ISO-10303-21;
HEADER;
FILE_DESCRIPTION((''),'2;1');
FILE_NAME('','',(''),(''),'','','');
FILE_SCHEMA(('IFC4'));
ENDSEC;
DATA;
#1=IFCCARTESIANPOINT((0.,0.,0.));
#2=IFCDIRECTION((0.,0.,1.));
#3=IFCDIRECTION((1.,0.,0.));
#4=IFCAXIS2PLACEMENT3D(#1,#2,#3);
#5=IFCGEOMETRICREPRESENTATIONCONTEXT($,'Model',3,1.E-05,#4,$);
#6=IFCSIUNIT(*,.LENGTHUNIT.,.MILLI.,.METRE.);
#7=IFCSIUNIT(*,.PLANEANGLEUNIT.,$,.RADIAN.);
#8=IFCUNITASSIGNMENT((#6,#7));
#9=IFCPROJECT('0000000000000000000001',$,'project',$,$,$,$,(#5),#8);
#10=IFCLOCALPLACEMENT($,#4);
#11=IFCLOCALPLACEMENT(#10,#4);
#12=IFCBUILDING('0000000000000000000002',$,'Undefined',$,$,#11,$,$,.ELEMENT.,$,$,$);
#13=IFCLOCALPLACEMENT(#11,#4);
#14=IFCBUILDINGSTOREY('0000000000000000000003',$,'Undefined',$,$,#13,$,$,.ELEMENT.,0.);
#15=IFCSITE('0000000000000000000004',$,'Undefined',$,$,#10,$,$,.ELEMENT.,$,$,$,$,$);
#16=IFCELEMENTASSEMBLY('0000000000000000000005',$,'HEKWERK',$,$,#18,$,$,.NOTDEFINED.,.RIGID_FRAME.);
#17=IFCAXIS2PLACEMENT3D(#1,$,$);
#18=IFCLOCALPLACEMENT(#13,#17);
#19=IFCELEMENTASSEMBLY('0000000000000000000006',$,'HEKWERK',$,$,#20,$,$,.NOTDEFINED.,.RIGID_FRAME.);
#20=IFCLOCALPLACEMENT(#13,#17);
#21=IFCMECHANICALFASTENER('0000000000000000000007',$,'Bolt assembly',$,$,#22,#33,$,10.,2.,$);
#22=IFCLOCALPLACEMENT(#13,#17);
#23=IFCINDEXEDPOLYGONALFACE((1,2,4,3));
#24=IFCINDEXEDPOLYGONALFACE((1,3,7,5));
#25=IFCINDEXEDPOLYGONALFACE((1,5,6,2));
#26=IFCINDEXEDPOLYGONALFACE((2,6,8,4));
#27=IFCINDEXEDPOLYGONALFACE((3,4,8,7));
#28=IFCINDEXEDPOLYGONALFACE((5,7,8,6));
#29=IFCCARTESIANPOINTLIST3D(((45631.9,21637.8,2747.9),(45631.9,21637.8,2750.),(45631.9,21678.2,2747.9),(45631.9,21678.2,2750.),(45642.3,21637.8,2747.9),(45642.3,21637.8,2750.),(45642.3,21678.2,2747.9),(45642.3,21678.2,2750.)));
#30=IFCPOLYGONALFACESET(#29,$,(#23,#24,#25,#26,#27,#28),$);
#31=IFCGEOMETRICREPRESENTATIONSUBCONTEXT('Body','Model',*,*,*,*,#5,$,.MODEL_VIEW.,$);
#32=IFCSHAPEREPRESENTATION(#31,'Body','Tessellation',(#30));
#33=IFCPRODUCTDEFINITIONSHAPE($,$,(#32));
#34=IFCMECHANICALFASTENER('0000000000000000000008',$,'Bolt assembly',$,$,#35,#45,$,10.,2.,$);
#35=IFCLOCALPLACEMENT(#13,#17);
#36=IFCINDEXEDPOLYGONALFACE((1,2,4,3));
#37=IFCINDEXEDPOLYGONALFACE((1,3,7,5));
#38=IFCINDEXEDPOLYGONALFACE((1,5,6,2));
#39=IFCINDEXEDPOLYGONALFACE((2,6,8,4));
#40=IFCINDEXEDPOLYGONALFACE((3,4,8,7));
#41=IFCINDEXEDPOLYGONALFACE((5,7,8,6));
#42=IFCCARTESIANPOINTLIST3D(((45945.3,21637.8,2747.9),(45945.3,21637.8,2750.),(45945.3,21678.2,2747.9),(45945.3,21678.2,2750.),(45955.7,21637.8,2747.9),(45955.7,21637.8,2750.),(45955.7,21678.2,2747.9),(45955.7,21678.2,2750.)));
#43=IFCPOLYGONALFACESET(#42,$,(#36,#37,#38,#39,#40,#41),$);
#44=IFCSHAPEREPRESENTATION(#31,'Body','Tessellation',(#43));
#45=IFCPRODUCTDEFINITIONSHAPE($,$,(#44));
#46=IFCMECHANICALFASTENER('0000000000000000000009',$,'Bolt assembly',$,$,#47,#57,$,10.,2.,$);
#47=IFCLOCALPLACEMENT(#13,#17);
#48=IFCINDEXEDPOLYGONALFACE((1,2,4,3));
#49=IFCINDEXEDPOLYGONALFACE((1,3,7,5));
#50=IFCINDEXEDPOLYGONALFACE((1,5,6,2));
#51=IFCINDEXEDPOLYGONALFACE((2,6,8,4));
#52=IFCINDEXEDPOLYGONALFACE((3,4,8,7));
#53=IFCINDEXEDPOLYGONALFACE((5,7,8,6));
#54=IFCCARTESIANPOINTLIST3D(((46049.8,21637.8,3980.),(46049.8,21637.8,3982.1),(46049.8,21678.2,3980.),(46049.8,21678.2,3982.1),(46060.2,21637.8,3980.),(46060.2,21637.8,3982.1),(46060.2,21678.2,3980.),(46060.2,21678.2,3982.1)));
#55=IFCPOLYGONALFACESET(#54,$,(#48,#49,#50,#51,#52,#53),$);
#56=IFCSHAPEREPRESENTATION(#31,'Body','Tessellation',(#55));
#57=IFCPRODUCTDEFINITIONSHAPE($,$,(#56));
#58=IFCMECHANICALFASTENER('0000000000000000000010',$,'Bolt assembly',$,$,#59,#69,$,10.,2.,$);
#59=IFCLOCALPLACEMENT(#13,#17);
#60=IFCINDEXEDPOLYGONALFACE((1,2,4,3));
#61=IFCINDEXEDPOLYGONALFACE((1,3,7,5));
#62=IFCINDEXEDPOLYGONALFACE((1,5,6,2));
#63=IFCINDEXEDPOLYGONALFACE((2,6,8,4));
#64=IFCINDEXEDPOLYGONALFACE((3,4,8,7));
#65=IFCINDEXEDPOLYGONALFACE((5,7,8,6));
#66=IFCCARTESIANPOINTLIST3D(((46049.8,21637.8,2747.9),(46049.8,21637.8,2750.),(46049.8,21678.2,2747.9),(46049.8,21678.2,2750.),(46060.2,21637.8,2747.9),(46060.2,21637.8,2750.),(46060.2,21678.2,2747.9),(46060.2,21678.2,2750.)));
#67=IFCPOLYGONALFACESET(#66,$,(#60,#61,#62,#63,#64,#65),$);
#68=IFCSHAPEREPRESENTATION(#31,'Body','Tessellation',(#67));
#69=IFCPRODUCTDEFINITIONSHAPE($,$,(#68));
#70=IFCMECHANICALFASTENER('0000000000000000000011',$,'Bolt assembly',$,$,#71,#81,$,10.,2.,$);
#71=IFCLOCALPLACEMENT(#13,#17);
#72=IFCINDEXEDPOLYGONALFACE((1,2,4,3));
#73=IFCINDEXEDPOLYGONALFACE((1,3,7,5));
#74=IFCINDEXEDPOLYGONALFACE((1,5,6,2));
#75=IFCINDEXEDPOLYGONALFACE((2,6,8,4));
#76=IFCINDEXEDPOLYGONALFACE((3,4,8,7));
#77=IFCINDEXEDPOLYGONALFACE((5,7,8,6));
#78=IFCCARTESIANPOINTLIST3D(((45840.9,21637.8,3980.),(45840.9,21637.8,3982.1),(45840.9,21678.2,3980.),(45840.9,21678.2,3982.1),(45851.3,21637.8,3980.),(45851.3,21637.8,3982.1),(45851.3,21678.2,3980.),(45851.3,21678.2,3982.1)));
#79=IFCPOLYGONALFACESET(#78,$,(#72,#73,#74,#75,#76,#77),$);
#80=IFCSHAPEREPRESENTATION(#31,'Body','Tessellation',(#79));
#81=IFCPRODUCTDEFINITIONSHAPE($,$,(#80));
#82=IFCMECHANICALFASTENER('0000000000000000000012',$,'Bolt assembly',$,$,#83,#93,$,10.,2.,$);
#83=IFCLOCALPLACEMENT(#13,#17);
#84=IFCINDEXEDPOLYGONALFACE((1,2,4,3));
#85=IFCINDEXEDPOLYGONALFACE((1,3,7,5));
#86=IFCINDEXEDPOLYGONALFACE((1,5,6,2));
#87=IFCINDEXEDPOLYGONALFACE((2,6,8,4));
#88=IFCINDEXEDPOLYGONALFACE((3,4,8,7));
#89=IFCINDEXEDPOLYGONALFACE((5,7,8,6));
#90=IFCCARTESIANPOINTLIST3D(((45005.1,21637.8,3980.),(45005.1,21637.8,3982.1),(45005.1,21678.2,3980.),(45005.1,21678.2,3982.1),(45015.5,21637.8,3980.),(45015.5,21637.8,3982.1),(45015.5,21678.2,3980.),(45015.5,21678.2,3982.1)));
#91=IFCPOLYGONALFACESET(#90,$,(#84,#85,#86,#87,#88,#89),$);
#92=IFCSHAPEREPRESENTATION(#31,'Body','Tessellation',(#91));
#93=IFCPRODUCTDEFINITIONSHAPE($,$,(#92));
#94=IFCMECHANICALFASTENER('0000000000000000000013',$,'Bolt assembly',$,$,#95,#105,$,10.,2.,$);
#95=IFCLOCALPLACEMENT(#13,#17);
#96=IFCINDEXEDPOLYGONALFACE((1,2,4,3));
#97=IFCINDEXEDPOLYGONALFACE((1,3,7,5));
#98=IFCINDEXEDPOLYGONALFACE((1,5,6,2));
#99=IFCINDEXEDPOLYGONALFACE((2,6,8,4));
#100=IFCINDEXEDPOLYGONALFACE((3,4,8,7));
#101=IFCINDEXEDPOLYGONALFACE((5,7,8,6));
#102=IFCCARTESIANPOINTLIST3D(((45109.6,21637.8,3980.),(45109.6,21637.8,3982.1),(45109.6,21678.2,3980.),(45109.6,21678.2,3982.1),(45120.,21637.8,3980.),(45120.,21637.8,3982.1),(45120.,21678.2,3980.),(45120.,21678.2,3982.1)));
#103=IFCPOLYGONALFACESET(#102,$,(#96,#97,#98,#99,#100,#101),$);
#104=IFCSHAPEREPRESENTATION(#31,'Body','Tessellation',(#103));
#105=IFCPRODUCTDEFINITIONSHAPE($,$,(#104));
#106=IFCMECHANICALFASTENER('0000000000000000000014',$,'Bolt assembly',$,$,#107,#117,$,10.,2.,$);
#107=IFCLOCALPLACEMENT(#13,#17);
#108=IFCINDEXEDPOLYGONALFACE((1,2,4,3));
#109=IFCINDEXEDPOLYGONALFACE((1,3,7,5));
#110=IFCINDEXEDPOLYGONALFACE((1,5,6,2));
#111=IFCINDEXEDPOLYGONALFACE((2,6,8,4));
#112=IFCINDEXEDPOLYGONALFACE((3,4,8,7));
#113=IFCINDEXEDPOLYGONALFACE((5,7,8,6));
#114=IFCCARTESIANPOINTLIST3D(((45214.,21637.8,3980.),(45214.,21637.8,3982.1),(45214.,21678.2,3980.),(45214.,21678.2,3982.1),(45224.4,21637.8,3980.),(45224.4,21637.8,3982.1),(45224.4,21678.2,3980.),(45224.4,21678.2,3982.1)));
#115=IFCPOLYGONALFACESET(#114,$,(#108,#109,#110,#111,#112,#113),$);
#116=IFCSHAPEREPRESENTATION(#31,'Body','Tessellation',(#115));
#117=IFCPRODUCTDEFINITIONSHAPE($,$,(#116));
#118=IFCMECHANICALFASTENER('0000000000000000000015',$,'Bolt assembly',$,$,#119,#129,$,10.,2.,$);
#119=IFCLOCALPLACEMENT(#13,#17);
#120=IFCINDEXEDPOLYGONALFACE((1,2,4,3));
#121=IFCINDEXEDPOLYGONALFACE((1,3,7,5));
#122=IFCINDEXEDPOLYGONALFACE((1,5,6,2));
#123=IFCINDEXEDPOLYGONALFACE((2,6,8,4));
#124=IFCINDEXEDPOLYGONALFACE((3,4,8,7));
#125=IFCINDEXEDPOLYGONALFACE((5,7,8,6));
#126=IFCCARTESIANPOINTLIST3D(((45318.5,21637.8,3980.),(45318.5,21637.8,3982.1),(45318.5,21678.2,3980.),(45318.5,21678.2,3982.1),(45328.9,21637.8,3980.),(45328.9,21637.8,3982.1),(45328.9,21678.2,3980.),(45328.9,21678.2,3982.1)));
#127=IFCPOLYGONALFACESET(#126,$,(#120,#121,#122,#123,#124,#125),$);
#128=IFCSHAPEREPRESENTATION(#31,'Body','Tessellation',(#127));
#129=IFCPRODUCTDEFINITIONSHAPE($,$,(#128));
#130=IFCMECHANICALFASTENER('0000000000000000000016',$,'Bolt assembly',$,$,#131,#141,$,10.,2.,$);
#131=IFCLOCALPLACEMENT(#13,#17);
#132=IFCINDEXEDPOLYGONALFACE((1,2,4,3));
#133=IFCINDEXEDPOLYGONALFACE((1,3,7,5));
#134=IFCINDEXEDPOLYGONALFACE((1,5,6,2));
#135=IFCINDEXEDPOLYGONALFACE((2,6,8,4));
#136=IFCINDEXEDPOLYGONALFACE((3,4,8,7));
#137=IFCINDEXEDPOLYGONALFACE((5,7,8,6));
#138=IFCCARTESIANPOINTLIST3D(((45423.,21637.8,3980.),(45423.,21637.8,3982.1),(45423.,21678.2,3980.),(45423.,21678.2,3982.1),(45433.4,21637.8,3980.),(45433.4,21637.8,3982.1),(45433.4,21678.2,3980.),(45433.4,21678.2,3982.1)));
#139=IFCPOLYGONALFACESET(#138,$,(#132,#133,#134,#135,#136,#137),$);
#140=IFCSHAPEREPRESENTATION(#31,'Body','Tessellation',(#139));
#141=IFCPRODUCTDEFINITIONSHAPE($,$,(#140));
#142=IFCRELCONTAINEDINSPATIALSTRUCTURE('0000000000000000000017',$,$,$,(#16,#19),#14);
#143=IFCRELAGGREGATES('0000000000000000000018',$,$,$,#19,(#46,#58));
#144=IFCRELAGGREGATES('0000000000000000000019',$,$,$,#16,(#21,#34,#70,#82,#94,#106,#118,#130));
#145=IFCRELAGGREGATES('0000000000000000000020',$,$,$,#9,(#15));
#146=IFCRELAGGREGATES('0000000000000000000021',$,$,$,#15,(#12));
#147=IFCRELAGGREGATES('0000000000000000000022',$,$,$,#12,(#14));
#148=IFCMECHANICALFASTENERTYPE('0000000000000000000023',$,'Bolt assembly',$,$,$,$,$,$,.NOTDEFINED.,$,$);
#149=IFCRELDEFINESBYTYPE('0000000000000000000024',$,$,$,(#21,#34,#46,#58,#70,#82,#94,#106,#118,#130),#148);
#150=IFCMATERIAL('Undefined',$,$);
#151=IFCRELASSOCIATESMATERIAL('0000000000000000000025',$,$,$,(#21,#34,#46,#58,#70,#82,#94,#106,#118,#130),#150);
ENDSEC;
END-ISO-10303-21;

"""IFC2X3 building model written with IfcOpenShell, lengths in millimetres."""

from ifc_helpers import new_model, si_unit, frame, origin_with_axes, place, context, subcontext, project, spatial, polyline, segment, composite_curve, outline, extrude, source, transform, mapped, material, type_object, element, aggregate, save


model = new_model("IFC2X3")

# Units and contexts
model_context = context("Model", 3, precision=1e-05, world=origin_with_axes())
body_context = subcontext(model_context, "Body", "Model", "MODEL_VIEW")
ifc_project = project(units=[si_unit("LENGTHUNIT", "METRE", prefix="MILLI"), si_unit("PLANEANGLEUNIT", "RADIAN")], contexts=[model_context])

# Site, building, storey
site_placement = place(None, origin_with_axes())
site = spatial("IfcSite", under=ifc_project, at=site_placement, Name="Undefined", CompositionType="ELEMENT")
building_placement = place(site_placement, origin_with_axes())
building = spatial("IfcBuilding", under=site, at=building_placement, Name="Undefined", CompositionType="ELEMENT")
storey_placement = place(building_placement, origin_with_axes())
storey = spatial("IfcBuildingStorey", under=building, at=storey_placement, Name="Undefined", CompositionType="ELEMENT", Elevation=0.0)

# Element assembly
assembly_1_placement = place(storey_placement, origin_with_axes())
assembly_1 = element("IfcElementAssembly", 1, at=assembly_1_placement, inside=storey, Name="HEKWERK", AssemblyPlace="NOTDEFINED", PredefinedType="RIGID_FRAME")

# Element assembly
assembly_2_placement = place(storey_placement, origin_with_axes())
assembly_2 = element("IfcElementAssembly", 2, at=assembly_2_placement, inside=storey, Name="HEKWERK", AssemblyPlace="NOTDEFINED", PredefinedType="RIGID_FRAME")

# Mechanical fasteners
ifc_material_1 = material(Name="Undefined")
mechanical_fastener_type = type_object("IfcMechanicalFastenerType", Name="Bolt assembly")
shared_shape_1 = source(origin_with_axes(), body_context, "Body", "SweptSolid", [
    extrude(outline(composite_curve([segment(polyline([(-20.2, 5.2), (20.2, 5.2)]), True, "CONTINUOUS"), segment(polyline([(20.2, 5.2), (20.2, -5.2)]), True, "CONTINUOUS"), segment(polyline([(20.2, -5.2), (-20.2, -5.2)]), True, "CONTINUOUS"), segment(polyline([(-20.2, -5.2), (-20.2, 5.2)]), True, "CONTINUOUS")], self_intersect=False)), frame((0.0, -1.0, 0.0), z_axis=(0.0, 1.0, 0.0), x_axis=(1.0, 0.0, 0.0)), (0.0, 0.0, 1.0), 2.1),
])
mechanical_fastener_1_placement = place(assembly_1_placement, frame((45637.1, 21658.0, 2749.0), z_axis=(-1.0, 0.0, 0.0), x_axis=(0.0, 1.0, 0.0)))
mechanical_fastener_1 = element("IfcMechanicalFastener", 3, at=mechanical_fastener_1_placement, type_object=mechanical_fastener_type, material=ifc_material_1, Name="Bolt assembly", NominalDiameter=10.0, NominalLength=2.0, context=body_context, shape_type="MappedRepresentation", body=[
    mapped(shared_shape_1, transform((0.0, 0.0, 0.0))),
])
shared_shape_2 = source(origin_with_axes(), body_context, "Body", "SweptSolid", [
    extrude(outline(composite_curve([segment(polyline([(-20.2, 5.2), (20.2, 5.2)]), True, "CONTINUOUS"), segment(polyline([(20.2, 5.2), (20.2, -5.2)]), True, "CONTINUOUS"), segment(polyline([(20.2, -5.2), (-20.2, -5.2)]), True, "CONTINUOUS"), segment(polyline([(-20.2, -5.2), (-20.2, 5.2)]), True, "CONTINUOUS")], self_intersect=False)), frame((0.0, -1.0, 0.0), z_axis=(0.0, 1.0, 0.0), x_axis=(1.0, 0.0, 0.0)), (0.0, 0.0, 1.0), 2.1),
])
mechanical_fastener_2_placement = place(assembly_1_placement, frame((45950.5, 21658.0, 2749.0), z_axis=(-1.0, 0.0, 0.0), x_axis=(0.0, 1.0, 0.0)))
mechanical_fastener_2 = element("IfcMechanicalFastener", 4, at=mechanical_fastener_2_placement, type_object=mechanical_fastener_type, material=ifc_material_1, Name="Bolt assembly", NominalDiameter=10.0, NominalLength=2.0, context=body_context, shape_type="MappedRepresentation", body=[
    mapped(shared_shape_2, transform((0.0, 0.0, 0.0))),
])
shared_shape_3 = source(origin_with_axes(), body_context, "Body", "SweptSolid", [
    extrude(outline(composite_curve([segment(polyline([(-20.2, 5.2), (20.2, 5.2)]), True, "CONTINUOUS"), segment(polyline([(20.2, 5.2), (20.2, -5.2)]), True, "CONTINUOUS"), segment(polyline([(20.2, -5.2), (-20.2, -5.2)]), True, "CONTINUOUS"), segment(polyline([(-20.2, -5.2), (-20.2, 5.2)]), True, "CONTINUOUS")], self_intersect=False)), frame((0.0, -1.0, 0.0), z_axis=(0.0, 1.0, 0.0), x_axis=(1.0, 0.0, 0.0)), (0.0, 0.0, 1.0), 2.1),
])
mechanical_fastener_3_placement = place(assembly_2_placement, frame((46055.0, 21658.0, 3981.0), z_axis=(1.0, 0.0, 0.0), x_axis=(0.0, 1.0, 0.0)))
mechanical_fastener_3 = element("IfcMechanicalFastener", 5, at=mechanical_fastener_3_placement, type_object=mechanical_fastener_type, material=ifc_material_1, Name="Bolt assembly", NominalDiameter=10.0, NominalLength=2.0, context=body_context, shape_type="MappedRepresentation", body=[
    mapped(shared_shape_3, transform((0.0, 0.0, 0.0))),
])
shared_shape_4 = source(origin_with_axes(), body_context, "Body", "SweptSolid", [
    extrude(outline(composite_curve([segment(polyline([(-20.2, 5.2), (20.2, 5.2)]), True, "CONTINUOUS"), segment(polyline([(20.2, 5.2), (20.2, -5.2)]), True, "CONTINUOUS"), segment(polyline([(20.2, -5.2), (-20.2, -5.2)]), True, "CONTINUOUS"), segment(polyline([(-20.2, -5.2), (-20.2, 5.2)]), True, "CONTINUOUS")], self_intersect=False)), frame((0.0, -1.0, 0.0), z_axis=(0.0, 1.0, 0.0), x_axis=(1.0, 0.0, 0.0)), (0.0, 0.0, 1.0), 2.1),
])
mechanical_fastener_4_placement = place(assembly_2_placement, frame((46055.0, 21658.0, 2749.0), z_axis=(-1.0, 0.0, 0.0), x_axis=(0.0, 1.0, 0.0)))
mechanical_fastener_4 = element("IfcMechanicalFastener", 6, at=mechanical_fastener_4_placement, type_object=mechanical_fastener_type, material=ifc_material_1, Name="Bolt assembly", NominalDiameter=10.0, NominalLength=2.0, context=body_context, shape_type="MappedRepresentation", body=[
    mapped(shared_shape_4, transform((0.0, 0.0, 0.0))),
])
aggregate(assembly_2, [mechanical_fastener_3, mechanical_fastener_4])
shared_shape_5 = source(origin_with_axes(), body_context, "Body", "SweptSolid", [
    extrude(outline(composite_curve([segment(polyline([(-20.2, 5.2), (20.2, 5.2)]), True, "CONTINUOUS"), segment(polyline([(20.2, 5.2), (20.2, -5.2)]), True, "CONTINUOUS"), segment(polyline([(20.2, -5.2), (-20.2, -5.2)]), True, "CONTINUOUS"), segment(polyline([(-20.2, -5.2), (-20.2, 5.2)]), True, "CONTINUOUS")], self_intersect=False)), frame((0.0, -1.0, 0.0), z_axis=(0.0, 1.0, 0.0), x_axis=(1.0, 0.0, 0.0)), (0.0, 0.0, 1.0), 2.1),
])
mechanical_fastener_5_placement = place(assembly_1_placement, frame((45846.1, 21658.0, 3981.0), z_axis=(1.0, 0.0, 0.0), x_axis=(0.0, 1.0, 0.0)))
mechanical_fastener_5 = element("IfcMechanicalFastener", 7, at=mechanical_fastener_5_placement, type_object=mechanical_fastener_type, material=ifc_material_1, Name="Bolt assembly", NominalDiameter=10.0, NominalLength=2.0, context=body_context, shape_type="MappedRepresentation", body=[
    mapped(shared_shape_5, transform((0.0, 0.0, 0.0))),
])
shared_shape_6 = source(origin_with_axes(), body_context, "Body", "SweptSolid", [
    extrude(outline(composite_curve([segment(polyline([(-20.2, 5.2), (20.2, 5.2)]), True, "CONTINUOUS"), segment(polyline([(20.2, 5.2), (20.2, -5.2)]), True, "CONTINUOUS"), segment(polyline([(20.2, -5.2), (-20.2, -5.2)]), True, "CONTINUOUS"), segment(polyline([(-20.2, -5.2), (-20.2, 5.2)]), True, "CONTINUOUS")], self_intersect=False)), frame((0.0, -1.0, 0.0), z_axis=(0.0, 1.0, 0.0), x_axis=(1.0, 0.0, 0.0)), (0.0, 0.0, 1.0), 2.1),
])
mechanical_fastener_6_placement = place(assembly_1_placement, frame((45010.3, 21658.0, 3981.0), z_axis=(1.0, 0.0, 0.0), x_axis=(0.0, 1.0, 0.0)))
mechanical_fastener_6 = element("IfcMechanicalFastener", 8, at=mechanical_fastener_6_placement, type_object=mechanical_fastener_type, material=ifc_material_1, Name="Bolt assembly", NominalDiameter=10.0, NominalLength=2.0, context=body_context, shape_type="MappedRepresentation", body=[
    mapped(shared_shape_6, transform((0.0, 0.0, 0.0))),
])
shared_shape_7 = source(origin_with_axes(), body_context, "Body", "SweptSolid", [
    extrude(outline(composite_curve([segment(polyline([(-20.2, 5.2), (20.2, 5.2)]), True, "CONTINUOUS"), segment(polyline([(20.2, 5.2), (20.2, -5.2)]), True, "CONTINUOUS"), segment(polyline([(20.2, -5.2), (-20.2, -5.2)]), True, "CONTINUOUS"), segment(polyline([(-20.2, -5.2), (-20.2, 5.2)]), True, "CONTINUOUS")], self_intersect=False)), frame((0.0, -1.0, 0.0), z_axis=(0.0, 1.0, 0.0), x_axis=(1.0, 0.0, 0.0)), (0.0, 0.0, 1.0), 2.1),
])
mechanical_fastener_7_placement = place(assembly_1_placement, frame((45114.8, 21658.0, 3981.0), z_axis=(1.0, 0.0, 0.0), x_axis=(0.0, 1.0, 0.0)))
mechanical_fastener_7 = element("IfcMechanicalFastener", 9, at=mechanical_fastener_7_placement, type_object=mechanical_fastener_type, material=ifc_material_1, Name="Bolt assembly", NominalDiameter=10.0, NominalLength=2.0, context=body_context, shape_type="MappedRepresentation", body=[
    mapped(shared_shape_7, transform((0.0, 0.0, 0.0))),
])
shared_shape_8 = source(origin_with_axes(), body_context, "Body", "SweptSolid", [
    extrude(outline(composite_curve([segment(polyline([(-20.2, 5.2), (20.2, 5.2)]), True, "CONTINUOUS"), segment(polyline([(20.2, 5.2), (20.2, -5.2)]), True, "CONTINUOUS"), segment(polyline([(20.2, -5.2), (-20.2, -5.2)]), True, "CONTINUOUS"), segment(polyline([(-20.2, -5.2), (-20.2, 5.2)]), True, "CONTINUOUS")], self_intersect=False)), frame((0.0, -1.0, 0.0), z_axis=(0.0, 1.0, 0.0), x_axis=(1.0, 0.0, 0.0)), (0.0, 0.0, 1.0), 2.1),
])
mechanical_fastener_8_placement = place(assembly_1_placement, frame((45219.2, 21658.0, 3981.0), z_axis=(1.0, 0.0, 0.0), x_axis=(0.0, 1.0, 0.0)))
mechanical_fastener_8 = element("IfcMechanicalFastener", 10, at=mechanical_fastener_8_placement, type_object=mechanical_fastener_type, material=ifc_material_1, Name="Bolt assembly", NominalDiameter=10.0, NominalLength=2.0, context=body_context, shape_type="MappedRepresentation", body=[
    mapped(shared_shape_8, transform((0.0, 0.0, 0.0))),
])
shared_shape_9 = source(origin_with_axes(), body_context, "Body", "SweptSolid", [
    extrude(outline(composite_curve([segment(polyline([(-20.2, 5.2), (20.2, 5.2)]), True, "CONTINUOUS"), segment(polyline([(20.2, 5.2), (20.2, -5.2)]), True, "CONTINUOUS"), segment(polyline([(20.2, -5.2), (-20.2, -5.2)]), True, "CONTINUOUS"), segment(polyline([(-20.2, -5.2), (-20.2, 5.2)]), True, "CONTINUOUS")], self_intersect=False)), frame((0.0, -1.0, 0.0), z_axis=(0.0, 1.0, 0.0), x_axis=(1.0, 0.0, 0.0)), (0.0, 0.0, 1.0), 2.1),
])
mechanical_fastener_9_placement = place(assembly_1_placement, frame((45323.7, 21658.0, 3981.0), z_axis=(1.0, 0.0, 0.0), x_axis=(0.0, 1.0, 0.0)))
mechanical_fastener_9 = element("IfcMechanicalFastener", 11, at=mechanical_fastener_9_placement, type_object=mechanical_fastener_type, material=ifc_material_1, Name="Bolt assembly", NominalDiameter=10.0, NominalLength=2.0, context=body_context, shape_type="MappedRepresentation", body=[
    mapped(shared_shape_9, transform((0.0, 0.0, 0.0))),
])
shared_shape_10 = source(origin_with_axes(), body_context, "Body", "SweptSolid", [
    extrude(outline(composite_curve([segment(polyline([(-20.2, 5.2), (20.2, 5.2)]), True, "CONTINUOUS"), segment(polyline([(20.2, 5.2), (20.2, -5.2)]), True, "CONTINUOUS"), segment(polyline([(20.2, -5.2), (-20.2, -5.2)]), True, "CONTINUOUS"), segment(polyline([(-20.2, -5.2), (-20.2, 5.2)]), True, "CONTINUOUS")], self_intersect=False)), frame((0.0, -1.0, 0.0), z_axis=(0.0, 1.0, 0.0), x_axis=(1.0, 0.0, 0.0)), (0.0, 0.0, 1.0), 2.1),
])
mechanical_fastener_10_placement = place(assembly_1_placement, frame((45428.2, 21658.0, 3981.0), z_axis=(1.0, 0.0, 0.0), x_axis=(0.0, 1.0, 0.0)))
mechanical_fastener_10 = element("IfcMechanicalFastener", 12, at=mechanical_fastener_10_placement, type_object=mechanical_fastener_type, material=ifc_material_1, Name="Bolt assembly", NominalDiameter=10.0, NominalLength=2.0, context=body_context, shape_type="MappedRepresentation", body=[
    mapped(shared_shape_10, transform((0.0, 0.0, 0.0))),
])
aggregate(assembly_1, [mechanical_fastener_1, mechanical_fastener_2, mechanical_fastener_5, mechanical_fastener_6, mechanical_fastener_7, mechanical_fastener_8, mechanical_fastener_9, mechanical_fastener_10])

save(model, "model.ifc")
